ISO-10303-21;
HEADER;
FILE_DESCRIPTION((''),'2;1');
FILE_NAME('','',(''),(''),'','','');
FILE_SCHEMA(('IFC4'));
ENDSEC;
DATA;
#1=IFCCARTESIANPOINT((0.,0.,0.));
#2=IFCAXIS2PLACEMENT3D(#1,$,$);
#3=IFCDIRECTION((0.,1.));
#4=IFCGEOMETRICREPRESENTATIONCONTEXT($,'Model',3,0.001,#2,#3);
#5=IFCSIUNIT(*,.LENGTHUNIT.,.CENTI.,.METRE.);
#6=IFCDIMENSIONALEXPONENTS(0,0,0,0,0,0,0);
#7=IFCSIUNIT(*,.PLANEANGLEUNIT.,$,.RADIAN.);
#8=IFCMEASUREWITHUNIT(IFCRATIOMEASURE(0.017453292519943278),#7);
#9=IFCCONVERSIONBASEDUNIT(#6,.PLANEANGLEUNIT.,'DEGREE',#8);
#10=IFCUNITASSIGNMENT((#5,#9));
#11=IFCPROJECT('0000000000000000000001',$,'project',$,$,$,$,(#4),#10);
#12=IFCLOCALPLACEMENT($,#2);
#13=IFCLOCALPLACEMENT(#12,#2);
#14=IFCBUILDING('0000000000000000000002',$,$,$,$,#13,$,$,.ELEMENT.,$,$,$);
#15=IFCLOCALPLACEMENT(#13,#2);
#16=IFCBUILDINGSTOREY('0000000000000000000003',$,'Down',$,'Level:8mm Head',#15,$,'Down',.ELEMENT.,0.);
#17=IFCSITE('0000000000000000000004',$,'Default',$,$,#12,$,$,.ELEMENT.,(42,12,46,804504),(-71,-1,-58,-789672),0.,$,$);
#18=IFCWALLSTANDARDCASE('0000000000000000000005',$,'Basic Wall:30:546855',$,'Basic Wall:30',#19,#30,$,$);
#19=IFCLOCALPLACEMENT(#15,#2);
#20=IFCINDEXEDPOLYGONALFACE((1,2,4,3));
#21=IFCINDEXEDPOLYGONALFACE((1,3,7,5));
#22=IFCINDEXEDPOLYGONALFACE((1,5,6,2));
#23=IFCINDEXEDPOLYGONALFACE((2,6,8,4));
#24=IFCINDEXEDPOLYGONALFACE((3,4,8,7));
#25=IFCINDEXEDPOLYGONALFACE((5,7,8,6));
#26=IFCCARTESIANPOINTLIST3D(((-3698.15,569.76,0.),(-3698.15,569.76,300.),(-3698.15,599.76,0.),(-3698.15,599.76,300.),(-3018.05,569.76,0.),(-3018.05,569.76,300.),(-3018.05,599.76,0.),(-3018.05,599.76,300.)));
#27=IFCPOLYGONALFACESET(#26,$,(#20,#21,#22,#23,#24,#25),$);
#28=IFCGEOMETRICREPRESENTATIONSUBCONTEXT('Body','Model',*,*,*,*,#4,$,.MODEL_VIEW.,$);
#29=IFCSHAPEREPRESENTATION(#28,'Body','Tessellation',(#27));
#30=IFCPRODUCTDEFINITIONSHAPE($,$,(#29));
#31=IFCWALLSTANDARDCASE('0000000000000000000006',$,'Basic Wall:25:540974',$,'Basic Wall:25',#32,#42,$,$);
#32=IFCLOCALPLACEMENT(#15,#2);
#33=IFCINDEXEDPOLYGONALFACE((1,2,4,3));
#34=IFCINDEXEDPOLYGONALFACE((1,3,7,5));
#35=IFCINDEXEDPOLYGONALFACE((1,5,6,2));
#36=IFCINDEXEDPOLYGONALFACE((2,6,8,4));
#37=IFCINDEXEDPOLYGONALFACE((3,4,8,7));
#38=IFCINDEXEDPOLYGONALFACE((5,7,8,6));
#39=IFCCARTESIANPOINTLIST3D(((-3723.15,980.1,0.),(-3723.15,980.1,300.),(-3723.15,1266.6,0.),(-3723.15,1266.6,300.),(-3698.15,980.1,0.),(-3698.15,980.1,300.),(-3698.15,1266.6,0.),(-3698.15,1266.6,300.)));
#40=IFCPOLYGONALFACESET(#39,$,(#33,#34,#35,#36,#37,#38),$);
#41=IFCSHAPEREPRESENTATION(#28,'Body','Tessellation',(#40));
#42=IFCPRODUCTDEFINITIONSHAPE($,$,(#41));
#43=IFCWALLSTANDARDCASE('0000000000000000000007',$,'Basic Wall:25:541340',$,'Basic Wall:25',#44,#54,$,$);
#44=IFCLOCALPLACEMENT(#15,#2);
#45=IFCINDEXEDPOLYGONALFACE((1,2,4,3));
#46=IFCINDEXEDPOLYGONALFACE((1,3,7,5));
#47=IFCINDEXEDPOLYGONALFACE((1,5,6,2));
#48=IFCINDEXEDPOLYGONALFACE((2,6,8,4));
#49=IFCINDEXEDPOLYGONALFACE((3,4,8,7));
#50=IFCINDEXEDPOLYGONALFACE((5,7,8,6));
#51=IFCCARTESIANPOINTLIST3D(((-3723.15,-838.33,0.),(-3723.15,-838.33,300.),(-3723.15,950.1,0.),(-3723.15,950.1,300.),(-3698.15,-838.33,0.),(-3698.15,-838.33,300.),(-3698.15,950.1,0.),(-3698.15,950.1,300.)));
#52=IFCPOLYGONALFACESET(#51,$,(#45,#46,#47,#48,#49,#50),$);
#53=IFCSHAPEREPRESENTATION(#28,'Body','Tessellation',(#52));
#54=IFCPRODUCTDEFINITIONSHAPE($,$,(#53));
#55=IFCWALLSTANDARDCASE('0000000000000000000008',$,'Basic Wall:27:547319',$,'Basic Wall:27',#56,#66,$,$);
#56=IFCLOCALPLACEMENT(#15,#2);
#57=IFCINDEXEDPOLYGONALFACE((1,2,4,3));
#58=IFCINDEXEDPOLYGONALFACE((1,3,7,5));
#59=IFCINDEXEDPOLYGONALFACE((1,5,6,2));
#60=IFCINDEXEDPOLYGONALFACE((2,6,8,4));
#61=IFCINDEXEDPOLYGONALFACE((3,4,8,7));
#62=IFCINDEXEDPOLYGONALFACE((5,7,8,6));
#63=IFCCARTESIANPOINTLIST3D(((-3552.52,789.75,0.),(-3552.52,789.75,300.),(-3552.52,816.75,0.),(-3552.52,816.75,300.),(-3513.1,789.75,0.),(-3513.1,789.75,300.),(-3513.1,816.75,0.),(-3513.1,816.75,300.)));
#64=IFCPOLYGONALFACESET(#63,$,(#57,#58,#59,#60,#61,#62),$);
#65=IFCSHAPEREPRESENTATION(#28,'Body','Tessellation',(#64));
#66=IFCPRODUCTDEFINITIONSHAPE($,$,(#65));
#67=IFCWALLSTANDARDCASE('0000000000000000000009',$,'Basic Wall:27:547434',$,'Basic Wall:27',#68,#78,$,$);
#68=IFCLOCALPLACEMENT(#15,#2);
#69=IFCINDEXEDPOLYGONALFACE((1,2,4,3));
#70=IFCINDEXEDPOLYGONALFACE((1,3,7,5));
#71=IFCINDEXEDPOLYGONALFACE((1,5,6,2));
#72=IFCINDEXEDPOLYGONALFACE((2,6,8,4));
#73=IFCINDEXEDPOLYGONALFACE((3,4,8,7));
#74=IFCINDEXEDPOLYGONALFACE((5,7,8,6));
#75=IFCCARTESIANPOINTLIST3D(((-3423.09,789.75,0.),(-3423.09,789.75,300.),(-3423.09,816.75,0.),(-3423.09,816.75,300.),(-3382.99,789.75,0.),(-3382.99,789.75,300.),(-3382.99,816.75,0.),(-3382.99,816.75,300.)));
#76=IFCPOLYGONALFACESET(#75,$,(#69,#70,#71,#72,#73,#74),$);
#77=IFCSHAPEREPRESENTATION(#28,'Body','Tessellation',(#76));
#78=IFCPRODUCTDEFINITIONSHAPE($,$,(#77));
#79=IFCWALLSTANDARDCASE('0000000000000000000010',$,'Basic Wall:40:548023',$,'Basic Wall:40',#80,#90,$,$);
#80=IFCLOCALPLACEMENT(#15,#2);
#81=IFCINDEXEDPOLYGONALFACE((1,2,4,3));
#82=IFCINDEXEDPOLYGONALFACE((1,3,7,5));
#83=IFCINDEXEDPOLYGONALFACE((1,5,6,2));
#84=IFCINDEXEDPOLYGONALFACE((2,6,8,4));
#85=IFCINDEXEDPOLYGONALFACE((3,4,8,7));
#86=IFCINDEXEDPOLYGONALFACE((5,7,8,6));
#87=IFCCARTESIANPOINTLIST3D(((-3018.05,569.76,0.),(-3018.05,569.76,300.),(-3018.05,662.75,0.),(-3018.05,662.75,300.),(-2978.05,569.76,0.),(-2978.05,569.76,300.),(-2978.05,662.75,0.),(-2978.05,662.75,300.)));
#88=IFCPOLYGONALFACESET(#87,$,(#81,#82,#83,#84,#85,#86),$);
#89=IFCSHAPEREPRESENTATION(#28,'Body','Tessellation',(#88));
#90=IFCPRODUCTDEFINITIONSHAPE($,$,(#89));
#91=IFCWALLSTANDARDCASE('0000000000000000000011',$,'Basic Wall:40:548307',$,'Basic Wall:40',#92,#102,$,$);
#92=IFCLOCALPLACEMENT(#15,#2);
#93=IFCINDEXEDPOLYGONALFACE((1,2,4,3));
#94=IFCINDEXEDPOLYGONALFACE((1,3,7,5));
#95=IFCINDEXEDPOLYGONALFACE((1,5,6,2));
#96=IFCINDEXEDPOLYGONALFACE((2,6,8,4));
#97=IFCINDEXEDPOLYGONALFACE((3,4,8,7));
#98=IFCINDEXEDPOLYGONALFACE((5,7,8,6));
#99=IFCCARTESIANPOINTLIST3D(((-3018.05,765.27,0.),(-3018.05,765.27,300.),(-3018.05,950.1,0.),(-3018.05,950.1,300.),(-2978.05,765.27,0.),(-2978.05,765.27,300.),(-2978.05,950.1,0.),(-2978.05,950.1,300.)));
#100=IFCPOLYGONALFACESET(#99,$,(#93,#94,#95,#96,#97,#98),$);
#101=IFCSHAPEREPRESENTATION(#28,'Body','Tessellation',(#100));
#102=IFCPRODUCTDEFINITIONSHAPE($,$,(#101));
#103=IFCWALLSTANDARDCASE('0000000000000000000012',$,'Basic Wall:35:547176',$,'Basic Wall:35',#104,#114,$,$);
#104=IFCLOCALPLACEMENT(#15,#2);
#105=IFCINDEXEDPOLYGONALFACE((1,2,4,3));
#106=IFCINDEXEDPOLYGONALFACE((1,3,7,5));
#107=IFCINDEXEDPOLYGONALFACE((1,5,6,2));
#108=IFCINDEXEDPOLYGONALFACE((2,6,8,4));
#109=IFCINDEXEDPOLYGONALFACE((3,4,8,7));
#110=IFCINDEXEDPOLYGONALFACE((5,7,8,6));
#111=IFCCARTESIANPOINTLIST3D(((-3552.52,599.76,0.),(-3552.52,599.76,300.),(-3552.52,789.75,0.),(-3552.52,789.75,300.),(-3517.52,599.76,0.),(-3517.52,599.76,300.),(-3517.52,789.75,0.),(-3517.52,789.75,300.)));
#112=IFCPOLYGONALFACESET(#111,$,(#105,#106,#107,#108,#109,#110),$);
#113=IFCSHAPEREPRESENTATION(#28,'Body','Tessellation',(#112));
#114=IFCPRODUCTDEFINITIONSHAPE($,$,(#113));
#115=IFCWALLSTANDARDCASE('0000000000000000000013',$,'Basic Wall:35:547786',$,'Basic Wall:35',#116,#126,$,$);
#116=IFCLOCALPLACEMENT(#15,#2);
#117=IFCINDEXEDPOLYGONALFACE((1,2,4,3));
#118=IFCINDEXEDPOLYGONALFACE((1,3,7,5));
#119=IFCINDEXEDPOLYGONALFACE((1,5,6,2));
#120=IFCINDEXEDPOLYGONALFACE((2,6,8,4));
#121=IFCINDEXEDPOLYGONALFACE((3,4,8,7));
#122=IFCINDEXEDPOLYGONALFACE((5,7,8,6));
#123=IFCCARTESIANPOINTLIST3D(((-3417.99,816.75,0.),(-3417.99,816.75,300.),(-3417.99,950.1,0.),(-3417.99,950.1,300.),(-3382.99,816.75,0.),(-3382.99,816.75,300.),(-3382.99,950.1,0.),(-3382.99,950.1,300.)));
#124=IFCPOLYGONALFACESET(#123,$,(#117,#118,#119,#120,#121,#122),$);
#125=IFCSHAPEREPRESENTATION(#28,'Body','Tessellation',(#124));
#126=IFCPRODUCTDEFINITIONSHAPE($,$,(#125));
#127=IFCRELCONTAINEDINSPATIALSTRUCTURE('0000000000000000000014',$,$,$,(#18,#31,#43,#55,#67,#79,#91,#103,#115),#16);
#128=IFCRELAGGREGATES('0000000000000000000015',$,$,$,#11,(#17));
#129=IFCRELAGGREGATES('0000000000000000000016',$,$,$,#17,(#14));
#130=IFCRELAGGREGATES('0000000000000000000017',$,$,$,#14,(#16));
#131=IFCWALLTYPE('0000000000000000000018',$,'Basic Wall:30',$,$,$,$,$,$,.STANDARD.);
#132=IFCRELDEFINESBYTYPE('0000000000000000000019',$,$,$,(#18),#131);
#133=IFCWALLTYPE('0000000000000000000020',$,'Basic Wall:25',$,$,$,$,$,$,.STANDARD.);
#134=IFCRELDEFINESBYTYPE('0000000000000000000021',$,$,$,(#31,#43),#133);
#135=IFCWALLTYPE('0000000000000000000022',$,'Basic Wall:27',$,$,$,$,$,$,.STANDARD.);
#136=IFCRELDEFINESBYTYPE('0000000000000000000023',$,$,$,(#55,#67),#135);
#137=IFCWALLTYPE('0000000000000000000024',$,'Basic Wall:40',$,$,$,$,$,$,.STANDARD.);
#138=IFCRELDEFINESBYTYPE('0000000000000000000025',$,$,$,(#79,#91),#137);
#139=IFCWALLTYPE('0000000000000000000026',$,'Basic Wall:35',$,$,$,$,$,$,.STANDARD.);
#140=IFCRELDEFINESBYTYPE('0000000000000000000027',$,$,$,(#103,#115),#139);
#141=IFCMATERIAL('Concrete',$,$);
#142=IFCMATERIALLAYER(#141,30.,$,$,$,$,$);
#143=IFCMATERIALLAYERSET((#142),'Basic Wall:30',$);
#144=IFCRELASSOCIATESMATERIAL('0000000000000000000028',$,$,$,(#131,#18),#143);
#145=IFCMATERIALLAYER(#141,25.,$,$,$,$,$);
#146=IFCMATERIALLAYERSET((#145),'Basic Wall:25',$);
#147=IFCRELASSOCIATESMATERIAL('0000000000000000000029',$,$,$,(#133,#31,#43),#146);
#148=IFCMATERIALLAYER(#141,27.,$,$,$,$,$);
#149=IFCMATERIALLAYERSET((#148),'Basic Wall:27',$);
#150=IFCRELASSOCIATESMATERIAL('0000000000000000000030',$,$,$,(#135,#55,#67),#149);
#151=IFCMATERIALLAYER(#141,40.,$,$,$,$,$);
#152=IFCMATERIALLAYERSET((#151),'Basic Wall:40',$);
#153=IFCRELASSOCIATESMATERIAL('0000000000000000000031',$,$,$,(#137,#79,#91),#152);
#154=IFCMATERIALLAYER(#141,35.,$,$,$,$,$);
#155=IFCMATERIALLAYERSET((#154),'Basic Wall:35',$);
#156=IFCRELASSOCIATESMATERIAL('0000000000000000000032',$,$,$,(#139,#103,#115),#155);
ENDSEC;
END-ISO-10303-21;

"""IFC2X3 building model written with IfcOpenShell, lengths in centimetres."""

from ifc_helpers import new_model, entity, si_unit, converted_unit, direction, frame, frame_2d, origin, place, context, subcontext, project, spatial, rectangle, extrude, material, layer, layer_set, layer_usage, type_object, element, save


model = new_model("IFC2X3")

# Units and contexts
model_context = context("Model", 3, precision=0.001, world=origin(), true_north=direction((0.0, 1.0)))
body_context = subcontext(model_context, "Body", "Model", "MODEL_VIEW")
ifc_project = project(units=[si_unit("LENGTHUNIT", "METRE", prefix="CENTI"), converted_unit("PLANEANGLEUNIT", "DEGREE", entity("IfcRatioMeasure", 0.017453292519943278), si_unit("PLANEANGLEUNIT", "RADIAN"), dimensions=[0, 0, 0, 0, 0, 0, 0])], contexts=[model_context])

# Site, building, storey
site_placement = place(None, origin())
site = spatial("IfcSite", under=ifc_project, at=site_placement, Name="Default", CompositionType="ELEMENT", RefLatitude=(42, 12, 46, 804504), RefLongitude=(-71, -1, -58, -789672), RefElevation=0.0)
building_placement = place(site_placement, origin())
building = spatial("IfcBuilding", under=site, at=building_placement, CompositionType="ELEMENT")
storey_placement = place(building_placement, origin())
storey = spatial("IfcBuildingStorey", under=building, at=storey_placement, Name="Down", ObjectType="Level:8mm Head", LongName="Down", CompositionType="ELEMENT", Elevation=0.0)

# Shared definitions
ifc_material = material(Name="Concrete")

# Walls
ifc_layer_1 = layer(ifc_material, 30.0)
ifc_layer_set_1 = layer_set([ifc_layer_1], Name="Basic Wall:30")
wall_type_1 = type_object("IfcWallType", Name="Basic Wall:30", PredefinedType="STANDARD", material=ifc_layer_set_1)
ifc_layer_usage_1 = layer_usage(ifc_layer_set_1, "AXIS2", "NEGATIVE", 15.0)
wall_1_placement = place(storey_placement, frame((-3698.15, 584.76, 0.0)))
element("IfcWallStandardCase", 1, at=wall_1_placement, inside=storey, type_object=wall_type_1, material=ifc_layer_usage_1, Name="Basic Wall:30:546855", ObjectType="Basic Wall:30", context=body_context, shape_type="SweptSolid", body=[
    extrude(rectangle(XDim=680.11, YDim=30.0, at=frame_2d((340.05, 0.0), x_axis=(-1.0, 0.0))), origin(), (0.0, 0.0, 1.0), 300.0),
])
ifc_layer_2 = layer(ifc_material, 25.0)
ifc_layer_set_2 = layer_set([ifc_layer_2], Name="Basic Wall:25")
ifc_layer_usage_2 = layer_usage(ifc_layer_set_2, "AXIS2", "POSITIVE", -12.5)
wall_type_2 = type_object("IfcWallType", Name="Basic Wall:25", PredefinedType="STANDARD", material=ifc_layer_set_2)
wall_2_placement = place(storey_placement, frame((-3710.65, 980.1, 0.0), z_axis=(0.0, 0.0, 1.0), x_axis=(0.0, 1.0, 0.0)))
element("IfcWallStandardCase", 2, at=wall_2_placement, inside=storey, type_object=wall_type_2, material=ifc_layer_usage_2, Name="Basic Wall:25:540974", ObjectType="Basic Wall:25", context=body_context, shape_type="SweptSolid", body=[
    extrude(rectangle(XDim=286.5, YDim=25.0, at=frame_2d((143.25, 0.0), x_axis=(-1.0, 0.0))), origin(), (0.0, 0.0, 1.0), 300.0),
])
ifc_layer_usage_3 = layer_usage(ifc_layer_set_2, "AXIS2", "POSITIVE", -12.5)
wall_3_placement = place(storey_placement, frame((-3710.65, 950.1, 0.0), z_axis=(0.0, 0.0, 1.0), x_axis=(0.0, -1.0, 0.0)))
element("IfcWallStandardCase", 3, at=wall_3_placement, inside=storey, type_object=wall_type_2, material=ifc_layer_usage_3, Name="Basic Wall:25:541340", ObjectType="Basic Wall:25", context=body_context, shape_type="SweptSolid", body=[
    extrude(rectangle(XDim=1788.43, YDim=25.0, at=frame_2d((894.22, 0.0), x_axis=(-1.0, 0.0))), origin(), (0.0, 0.0, 1.0), 300.0),
])
ifc_layer_3 = layer(ifc_material, 27.0)
ifc_layer_set_3 = layer_set([ifc_layer_3], Name="Basic Wall:27")
ifc_layer_usage_4 = layer_usage(ifc_layer_set_3, "AXIS2", "NEGATIVE", 13.5)
wall_type_3 = type_object("IfcWallType", Name="Basic Wall:27", PredefinedType="STANDARD", material=ifc_layer_set_3)
wall_4_placement = place(storey_placement, frame((-3552.52, 803.25, 0.0)))
element("IfcWallStandardCase", 4, at=wall_4_placement, inside=storey, type_object=wall_type_3, material=ifc_layer_usage_4, Name="Basic Wall:27:547319", ObjectType="Basic Wall:27", context=body_context, shape_type="SweptSolid", body=[
    extrude(rectangle(XDim=39.42, YDim=27.0, at=frame_2d((19.71, 0.0), x_axis=(-1.0, 0.0))), origin(), (0.0, 0.0, 1.0), 300.0),
])
ifc_layer_usage_5 = layer_usage(ifc_layer_set_3, "AXIS2", "NEGATIVE", 13.5)
wall_5_placement = place(storey_placement, frame((-3423.09, 803.25, 0.0)))
element("IfcWallStandardCase", 5, at=wall_5_placement, inside=storey, type_object=wall_type_3, material=ifc_layer_usage_5, Name="Basic Wall:27:547434", ObjectType="Basic Wall:27", context=body_context, shape_type="SweptSolid", body=[
    extrude(rectangle(XDim=40.09, YDim=27.0, at=frame_2d((20.05, 0.0), x_axis=(-1.0, 0.0))), origin(), (0.0, 0.0, 1.0), 300.0),
])
ifc_layer_4 = layer(ifc_material, 40.0)
ifc_layer_set_4 = layer_set([ifc_layer_4], Name="Basic Wall:40")
ifc_layer_usage_6 = layer_usage(ifc_layer_set_4, "AXIS2", "POSITIVE", -20.0)
wall_type_4 = type_object("IfcWallType", Name="Basic Wall:40", PredefinedType="STANDARD", material=ifc_layer_set_4)
wall_6_placement = place(storey_placement, frame((-2998.05, 569.76, 0.0), z_axis=(0.0, 0.0, 1.0), x_axis=(0.0, 1.0, 0.0)))
element("IfcWallStandardCase", 6, at=wall_6_placement, inside=storey, type_object=wall_type_4, material=ifc_layer_usage_6, Name="Basic Wall:40:548023", ObjectType="Basic Wall:40", context=body_context, shape_type="SweptSolid", body=[
    extrude(rectangle(XDim=92.99, YDim=40.0, at=frame_2d((46.49, 0.0), x_axis=(-1.0, 0.0))), origin(), (0.0, 0.0, 1.0), 300.0),
])
ifc_layer_usage_7 = layer_usage(ifc_layer_set_4, "AXIS2", "POSITIVE", -20.0)
wall_7_placement = place(storey_placement, frame((-2998.05, 765.27, 0.0), z_axis=(0.0, 0.0, 1.0), x_axis=(0.0, 1.0, 0.0)))
element("IfcWallStandardCase", 7, at=wall_7_placement, inside=storey, type_object=wall_type_4, material=ifc_layer_usage_7, Name="Basic Wall:40:548307", ObjectType="Basic Wall:40", context=body_context, shape_type="SweptSolid", body=[
    extrude(rectangle(XDim=184.83, YDim=40.0, at=frame_2d((92.41, 0.0), x_axis=(-1.0, 0.0))), origin(), (0.0, 0.0, 1.0), 300.0),
])
ifc_layer_5 = layer(ifc_material, 35.0)
ifc_layer_set_5 = layer_set([ifc_layer_5], Name="Basic Wall:35")
ifc_layer_usage_8 = layer_usage(ifc_layer_set_5, "AXIS2", "NEGATIVE", 17.5)
wall_type_5 = type_object("IfcWallType", Name="Basic Wall:35", PredefinedType="STANDARD", material=ifc_layer_set_5)
wall_8_placement = place(storey_placement, frame((-3535.02, 599.76, 0.0), z_axis=(0.0, 0.0, 1.0), x_axis=(0.0, 1.0, 0.0)))
element("IfcWallStandardCase", 8, at=wall_8_placement, inside=storey, type_object=wall_type_5, material=ifc_layer_usage_8, Name="Basic Wall:35:547176", ObjectType="Basic Wall:35", context=body_context, shape_type="SweptSolid", body=[
    extrude(rectangle(XDim=189.99, YDim=35.0, at=frame_2d((95.0, 0.0), x_axis=(-1.0, 0.0))), origin(), (0.0, 0.0, 1.0), 300.0),
])
ifc_layer_usage_9 = layer_usage(ifc_layer_set_5, "AXIS2", "POSITIVE", -17.5)
wall_9_placement = place(storey_placement, frame((-3400.49, 816.75, 0.0), z_axis=(0.0, 0.0, 1.0), x_axis=(0.0, 1.0, 0.0)))
element("IfcWallStandardCase", 9, at=wall_9_placement, inside=storey, type_object=wall_type_5, material=ifc_layer_usage_9, Name="Basic Wall:35:547786", ObjectType="Basic Wall:35", context=body_context, shape_type="SweptSolid", body=[
    extrude(rectangle(XDim=133.34, YDim=35.0, at=frame_2d((66.67, 0.0), x_axis=(-1.0, 0.0))), origin(), (0.0, 0.0, 1.0), 300.0),
])

save(model, "model.ifc")
